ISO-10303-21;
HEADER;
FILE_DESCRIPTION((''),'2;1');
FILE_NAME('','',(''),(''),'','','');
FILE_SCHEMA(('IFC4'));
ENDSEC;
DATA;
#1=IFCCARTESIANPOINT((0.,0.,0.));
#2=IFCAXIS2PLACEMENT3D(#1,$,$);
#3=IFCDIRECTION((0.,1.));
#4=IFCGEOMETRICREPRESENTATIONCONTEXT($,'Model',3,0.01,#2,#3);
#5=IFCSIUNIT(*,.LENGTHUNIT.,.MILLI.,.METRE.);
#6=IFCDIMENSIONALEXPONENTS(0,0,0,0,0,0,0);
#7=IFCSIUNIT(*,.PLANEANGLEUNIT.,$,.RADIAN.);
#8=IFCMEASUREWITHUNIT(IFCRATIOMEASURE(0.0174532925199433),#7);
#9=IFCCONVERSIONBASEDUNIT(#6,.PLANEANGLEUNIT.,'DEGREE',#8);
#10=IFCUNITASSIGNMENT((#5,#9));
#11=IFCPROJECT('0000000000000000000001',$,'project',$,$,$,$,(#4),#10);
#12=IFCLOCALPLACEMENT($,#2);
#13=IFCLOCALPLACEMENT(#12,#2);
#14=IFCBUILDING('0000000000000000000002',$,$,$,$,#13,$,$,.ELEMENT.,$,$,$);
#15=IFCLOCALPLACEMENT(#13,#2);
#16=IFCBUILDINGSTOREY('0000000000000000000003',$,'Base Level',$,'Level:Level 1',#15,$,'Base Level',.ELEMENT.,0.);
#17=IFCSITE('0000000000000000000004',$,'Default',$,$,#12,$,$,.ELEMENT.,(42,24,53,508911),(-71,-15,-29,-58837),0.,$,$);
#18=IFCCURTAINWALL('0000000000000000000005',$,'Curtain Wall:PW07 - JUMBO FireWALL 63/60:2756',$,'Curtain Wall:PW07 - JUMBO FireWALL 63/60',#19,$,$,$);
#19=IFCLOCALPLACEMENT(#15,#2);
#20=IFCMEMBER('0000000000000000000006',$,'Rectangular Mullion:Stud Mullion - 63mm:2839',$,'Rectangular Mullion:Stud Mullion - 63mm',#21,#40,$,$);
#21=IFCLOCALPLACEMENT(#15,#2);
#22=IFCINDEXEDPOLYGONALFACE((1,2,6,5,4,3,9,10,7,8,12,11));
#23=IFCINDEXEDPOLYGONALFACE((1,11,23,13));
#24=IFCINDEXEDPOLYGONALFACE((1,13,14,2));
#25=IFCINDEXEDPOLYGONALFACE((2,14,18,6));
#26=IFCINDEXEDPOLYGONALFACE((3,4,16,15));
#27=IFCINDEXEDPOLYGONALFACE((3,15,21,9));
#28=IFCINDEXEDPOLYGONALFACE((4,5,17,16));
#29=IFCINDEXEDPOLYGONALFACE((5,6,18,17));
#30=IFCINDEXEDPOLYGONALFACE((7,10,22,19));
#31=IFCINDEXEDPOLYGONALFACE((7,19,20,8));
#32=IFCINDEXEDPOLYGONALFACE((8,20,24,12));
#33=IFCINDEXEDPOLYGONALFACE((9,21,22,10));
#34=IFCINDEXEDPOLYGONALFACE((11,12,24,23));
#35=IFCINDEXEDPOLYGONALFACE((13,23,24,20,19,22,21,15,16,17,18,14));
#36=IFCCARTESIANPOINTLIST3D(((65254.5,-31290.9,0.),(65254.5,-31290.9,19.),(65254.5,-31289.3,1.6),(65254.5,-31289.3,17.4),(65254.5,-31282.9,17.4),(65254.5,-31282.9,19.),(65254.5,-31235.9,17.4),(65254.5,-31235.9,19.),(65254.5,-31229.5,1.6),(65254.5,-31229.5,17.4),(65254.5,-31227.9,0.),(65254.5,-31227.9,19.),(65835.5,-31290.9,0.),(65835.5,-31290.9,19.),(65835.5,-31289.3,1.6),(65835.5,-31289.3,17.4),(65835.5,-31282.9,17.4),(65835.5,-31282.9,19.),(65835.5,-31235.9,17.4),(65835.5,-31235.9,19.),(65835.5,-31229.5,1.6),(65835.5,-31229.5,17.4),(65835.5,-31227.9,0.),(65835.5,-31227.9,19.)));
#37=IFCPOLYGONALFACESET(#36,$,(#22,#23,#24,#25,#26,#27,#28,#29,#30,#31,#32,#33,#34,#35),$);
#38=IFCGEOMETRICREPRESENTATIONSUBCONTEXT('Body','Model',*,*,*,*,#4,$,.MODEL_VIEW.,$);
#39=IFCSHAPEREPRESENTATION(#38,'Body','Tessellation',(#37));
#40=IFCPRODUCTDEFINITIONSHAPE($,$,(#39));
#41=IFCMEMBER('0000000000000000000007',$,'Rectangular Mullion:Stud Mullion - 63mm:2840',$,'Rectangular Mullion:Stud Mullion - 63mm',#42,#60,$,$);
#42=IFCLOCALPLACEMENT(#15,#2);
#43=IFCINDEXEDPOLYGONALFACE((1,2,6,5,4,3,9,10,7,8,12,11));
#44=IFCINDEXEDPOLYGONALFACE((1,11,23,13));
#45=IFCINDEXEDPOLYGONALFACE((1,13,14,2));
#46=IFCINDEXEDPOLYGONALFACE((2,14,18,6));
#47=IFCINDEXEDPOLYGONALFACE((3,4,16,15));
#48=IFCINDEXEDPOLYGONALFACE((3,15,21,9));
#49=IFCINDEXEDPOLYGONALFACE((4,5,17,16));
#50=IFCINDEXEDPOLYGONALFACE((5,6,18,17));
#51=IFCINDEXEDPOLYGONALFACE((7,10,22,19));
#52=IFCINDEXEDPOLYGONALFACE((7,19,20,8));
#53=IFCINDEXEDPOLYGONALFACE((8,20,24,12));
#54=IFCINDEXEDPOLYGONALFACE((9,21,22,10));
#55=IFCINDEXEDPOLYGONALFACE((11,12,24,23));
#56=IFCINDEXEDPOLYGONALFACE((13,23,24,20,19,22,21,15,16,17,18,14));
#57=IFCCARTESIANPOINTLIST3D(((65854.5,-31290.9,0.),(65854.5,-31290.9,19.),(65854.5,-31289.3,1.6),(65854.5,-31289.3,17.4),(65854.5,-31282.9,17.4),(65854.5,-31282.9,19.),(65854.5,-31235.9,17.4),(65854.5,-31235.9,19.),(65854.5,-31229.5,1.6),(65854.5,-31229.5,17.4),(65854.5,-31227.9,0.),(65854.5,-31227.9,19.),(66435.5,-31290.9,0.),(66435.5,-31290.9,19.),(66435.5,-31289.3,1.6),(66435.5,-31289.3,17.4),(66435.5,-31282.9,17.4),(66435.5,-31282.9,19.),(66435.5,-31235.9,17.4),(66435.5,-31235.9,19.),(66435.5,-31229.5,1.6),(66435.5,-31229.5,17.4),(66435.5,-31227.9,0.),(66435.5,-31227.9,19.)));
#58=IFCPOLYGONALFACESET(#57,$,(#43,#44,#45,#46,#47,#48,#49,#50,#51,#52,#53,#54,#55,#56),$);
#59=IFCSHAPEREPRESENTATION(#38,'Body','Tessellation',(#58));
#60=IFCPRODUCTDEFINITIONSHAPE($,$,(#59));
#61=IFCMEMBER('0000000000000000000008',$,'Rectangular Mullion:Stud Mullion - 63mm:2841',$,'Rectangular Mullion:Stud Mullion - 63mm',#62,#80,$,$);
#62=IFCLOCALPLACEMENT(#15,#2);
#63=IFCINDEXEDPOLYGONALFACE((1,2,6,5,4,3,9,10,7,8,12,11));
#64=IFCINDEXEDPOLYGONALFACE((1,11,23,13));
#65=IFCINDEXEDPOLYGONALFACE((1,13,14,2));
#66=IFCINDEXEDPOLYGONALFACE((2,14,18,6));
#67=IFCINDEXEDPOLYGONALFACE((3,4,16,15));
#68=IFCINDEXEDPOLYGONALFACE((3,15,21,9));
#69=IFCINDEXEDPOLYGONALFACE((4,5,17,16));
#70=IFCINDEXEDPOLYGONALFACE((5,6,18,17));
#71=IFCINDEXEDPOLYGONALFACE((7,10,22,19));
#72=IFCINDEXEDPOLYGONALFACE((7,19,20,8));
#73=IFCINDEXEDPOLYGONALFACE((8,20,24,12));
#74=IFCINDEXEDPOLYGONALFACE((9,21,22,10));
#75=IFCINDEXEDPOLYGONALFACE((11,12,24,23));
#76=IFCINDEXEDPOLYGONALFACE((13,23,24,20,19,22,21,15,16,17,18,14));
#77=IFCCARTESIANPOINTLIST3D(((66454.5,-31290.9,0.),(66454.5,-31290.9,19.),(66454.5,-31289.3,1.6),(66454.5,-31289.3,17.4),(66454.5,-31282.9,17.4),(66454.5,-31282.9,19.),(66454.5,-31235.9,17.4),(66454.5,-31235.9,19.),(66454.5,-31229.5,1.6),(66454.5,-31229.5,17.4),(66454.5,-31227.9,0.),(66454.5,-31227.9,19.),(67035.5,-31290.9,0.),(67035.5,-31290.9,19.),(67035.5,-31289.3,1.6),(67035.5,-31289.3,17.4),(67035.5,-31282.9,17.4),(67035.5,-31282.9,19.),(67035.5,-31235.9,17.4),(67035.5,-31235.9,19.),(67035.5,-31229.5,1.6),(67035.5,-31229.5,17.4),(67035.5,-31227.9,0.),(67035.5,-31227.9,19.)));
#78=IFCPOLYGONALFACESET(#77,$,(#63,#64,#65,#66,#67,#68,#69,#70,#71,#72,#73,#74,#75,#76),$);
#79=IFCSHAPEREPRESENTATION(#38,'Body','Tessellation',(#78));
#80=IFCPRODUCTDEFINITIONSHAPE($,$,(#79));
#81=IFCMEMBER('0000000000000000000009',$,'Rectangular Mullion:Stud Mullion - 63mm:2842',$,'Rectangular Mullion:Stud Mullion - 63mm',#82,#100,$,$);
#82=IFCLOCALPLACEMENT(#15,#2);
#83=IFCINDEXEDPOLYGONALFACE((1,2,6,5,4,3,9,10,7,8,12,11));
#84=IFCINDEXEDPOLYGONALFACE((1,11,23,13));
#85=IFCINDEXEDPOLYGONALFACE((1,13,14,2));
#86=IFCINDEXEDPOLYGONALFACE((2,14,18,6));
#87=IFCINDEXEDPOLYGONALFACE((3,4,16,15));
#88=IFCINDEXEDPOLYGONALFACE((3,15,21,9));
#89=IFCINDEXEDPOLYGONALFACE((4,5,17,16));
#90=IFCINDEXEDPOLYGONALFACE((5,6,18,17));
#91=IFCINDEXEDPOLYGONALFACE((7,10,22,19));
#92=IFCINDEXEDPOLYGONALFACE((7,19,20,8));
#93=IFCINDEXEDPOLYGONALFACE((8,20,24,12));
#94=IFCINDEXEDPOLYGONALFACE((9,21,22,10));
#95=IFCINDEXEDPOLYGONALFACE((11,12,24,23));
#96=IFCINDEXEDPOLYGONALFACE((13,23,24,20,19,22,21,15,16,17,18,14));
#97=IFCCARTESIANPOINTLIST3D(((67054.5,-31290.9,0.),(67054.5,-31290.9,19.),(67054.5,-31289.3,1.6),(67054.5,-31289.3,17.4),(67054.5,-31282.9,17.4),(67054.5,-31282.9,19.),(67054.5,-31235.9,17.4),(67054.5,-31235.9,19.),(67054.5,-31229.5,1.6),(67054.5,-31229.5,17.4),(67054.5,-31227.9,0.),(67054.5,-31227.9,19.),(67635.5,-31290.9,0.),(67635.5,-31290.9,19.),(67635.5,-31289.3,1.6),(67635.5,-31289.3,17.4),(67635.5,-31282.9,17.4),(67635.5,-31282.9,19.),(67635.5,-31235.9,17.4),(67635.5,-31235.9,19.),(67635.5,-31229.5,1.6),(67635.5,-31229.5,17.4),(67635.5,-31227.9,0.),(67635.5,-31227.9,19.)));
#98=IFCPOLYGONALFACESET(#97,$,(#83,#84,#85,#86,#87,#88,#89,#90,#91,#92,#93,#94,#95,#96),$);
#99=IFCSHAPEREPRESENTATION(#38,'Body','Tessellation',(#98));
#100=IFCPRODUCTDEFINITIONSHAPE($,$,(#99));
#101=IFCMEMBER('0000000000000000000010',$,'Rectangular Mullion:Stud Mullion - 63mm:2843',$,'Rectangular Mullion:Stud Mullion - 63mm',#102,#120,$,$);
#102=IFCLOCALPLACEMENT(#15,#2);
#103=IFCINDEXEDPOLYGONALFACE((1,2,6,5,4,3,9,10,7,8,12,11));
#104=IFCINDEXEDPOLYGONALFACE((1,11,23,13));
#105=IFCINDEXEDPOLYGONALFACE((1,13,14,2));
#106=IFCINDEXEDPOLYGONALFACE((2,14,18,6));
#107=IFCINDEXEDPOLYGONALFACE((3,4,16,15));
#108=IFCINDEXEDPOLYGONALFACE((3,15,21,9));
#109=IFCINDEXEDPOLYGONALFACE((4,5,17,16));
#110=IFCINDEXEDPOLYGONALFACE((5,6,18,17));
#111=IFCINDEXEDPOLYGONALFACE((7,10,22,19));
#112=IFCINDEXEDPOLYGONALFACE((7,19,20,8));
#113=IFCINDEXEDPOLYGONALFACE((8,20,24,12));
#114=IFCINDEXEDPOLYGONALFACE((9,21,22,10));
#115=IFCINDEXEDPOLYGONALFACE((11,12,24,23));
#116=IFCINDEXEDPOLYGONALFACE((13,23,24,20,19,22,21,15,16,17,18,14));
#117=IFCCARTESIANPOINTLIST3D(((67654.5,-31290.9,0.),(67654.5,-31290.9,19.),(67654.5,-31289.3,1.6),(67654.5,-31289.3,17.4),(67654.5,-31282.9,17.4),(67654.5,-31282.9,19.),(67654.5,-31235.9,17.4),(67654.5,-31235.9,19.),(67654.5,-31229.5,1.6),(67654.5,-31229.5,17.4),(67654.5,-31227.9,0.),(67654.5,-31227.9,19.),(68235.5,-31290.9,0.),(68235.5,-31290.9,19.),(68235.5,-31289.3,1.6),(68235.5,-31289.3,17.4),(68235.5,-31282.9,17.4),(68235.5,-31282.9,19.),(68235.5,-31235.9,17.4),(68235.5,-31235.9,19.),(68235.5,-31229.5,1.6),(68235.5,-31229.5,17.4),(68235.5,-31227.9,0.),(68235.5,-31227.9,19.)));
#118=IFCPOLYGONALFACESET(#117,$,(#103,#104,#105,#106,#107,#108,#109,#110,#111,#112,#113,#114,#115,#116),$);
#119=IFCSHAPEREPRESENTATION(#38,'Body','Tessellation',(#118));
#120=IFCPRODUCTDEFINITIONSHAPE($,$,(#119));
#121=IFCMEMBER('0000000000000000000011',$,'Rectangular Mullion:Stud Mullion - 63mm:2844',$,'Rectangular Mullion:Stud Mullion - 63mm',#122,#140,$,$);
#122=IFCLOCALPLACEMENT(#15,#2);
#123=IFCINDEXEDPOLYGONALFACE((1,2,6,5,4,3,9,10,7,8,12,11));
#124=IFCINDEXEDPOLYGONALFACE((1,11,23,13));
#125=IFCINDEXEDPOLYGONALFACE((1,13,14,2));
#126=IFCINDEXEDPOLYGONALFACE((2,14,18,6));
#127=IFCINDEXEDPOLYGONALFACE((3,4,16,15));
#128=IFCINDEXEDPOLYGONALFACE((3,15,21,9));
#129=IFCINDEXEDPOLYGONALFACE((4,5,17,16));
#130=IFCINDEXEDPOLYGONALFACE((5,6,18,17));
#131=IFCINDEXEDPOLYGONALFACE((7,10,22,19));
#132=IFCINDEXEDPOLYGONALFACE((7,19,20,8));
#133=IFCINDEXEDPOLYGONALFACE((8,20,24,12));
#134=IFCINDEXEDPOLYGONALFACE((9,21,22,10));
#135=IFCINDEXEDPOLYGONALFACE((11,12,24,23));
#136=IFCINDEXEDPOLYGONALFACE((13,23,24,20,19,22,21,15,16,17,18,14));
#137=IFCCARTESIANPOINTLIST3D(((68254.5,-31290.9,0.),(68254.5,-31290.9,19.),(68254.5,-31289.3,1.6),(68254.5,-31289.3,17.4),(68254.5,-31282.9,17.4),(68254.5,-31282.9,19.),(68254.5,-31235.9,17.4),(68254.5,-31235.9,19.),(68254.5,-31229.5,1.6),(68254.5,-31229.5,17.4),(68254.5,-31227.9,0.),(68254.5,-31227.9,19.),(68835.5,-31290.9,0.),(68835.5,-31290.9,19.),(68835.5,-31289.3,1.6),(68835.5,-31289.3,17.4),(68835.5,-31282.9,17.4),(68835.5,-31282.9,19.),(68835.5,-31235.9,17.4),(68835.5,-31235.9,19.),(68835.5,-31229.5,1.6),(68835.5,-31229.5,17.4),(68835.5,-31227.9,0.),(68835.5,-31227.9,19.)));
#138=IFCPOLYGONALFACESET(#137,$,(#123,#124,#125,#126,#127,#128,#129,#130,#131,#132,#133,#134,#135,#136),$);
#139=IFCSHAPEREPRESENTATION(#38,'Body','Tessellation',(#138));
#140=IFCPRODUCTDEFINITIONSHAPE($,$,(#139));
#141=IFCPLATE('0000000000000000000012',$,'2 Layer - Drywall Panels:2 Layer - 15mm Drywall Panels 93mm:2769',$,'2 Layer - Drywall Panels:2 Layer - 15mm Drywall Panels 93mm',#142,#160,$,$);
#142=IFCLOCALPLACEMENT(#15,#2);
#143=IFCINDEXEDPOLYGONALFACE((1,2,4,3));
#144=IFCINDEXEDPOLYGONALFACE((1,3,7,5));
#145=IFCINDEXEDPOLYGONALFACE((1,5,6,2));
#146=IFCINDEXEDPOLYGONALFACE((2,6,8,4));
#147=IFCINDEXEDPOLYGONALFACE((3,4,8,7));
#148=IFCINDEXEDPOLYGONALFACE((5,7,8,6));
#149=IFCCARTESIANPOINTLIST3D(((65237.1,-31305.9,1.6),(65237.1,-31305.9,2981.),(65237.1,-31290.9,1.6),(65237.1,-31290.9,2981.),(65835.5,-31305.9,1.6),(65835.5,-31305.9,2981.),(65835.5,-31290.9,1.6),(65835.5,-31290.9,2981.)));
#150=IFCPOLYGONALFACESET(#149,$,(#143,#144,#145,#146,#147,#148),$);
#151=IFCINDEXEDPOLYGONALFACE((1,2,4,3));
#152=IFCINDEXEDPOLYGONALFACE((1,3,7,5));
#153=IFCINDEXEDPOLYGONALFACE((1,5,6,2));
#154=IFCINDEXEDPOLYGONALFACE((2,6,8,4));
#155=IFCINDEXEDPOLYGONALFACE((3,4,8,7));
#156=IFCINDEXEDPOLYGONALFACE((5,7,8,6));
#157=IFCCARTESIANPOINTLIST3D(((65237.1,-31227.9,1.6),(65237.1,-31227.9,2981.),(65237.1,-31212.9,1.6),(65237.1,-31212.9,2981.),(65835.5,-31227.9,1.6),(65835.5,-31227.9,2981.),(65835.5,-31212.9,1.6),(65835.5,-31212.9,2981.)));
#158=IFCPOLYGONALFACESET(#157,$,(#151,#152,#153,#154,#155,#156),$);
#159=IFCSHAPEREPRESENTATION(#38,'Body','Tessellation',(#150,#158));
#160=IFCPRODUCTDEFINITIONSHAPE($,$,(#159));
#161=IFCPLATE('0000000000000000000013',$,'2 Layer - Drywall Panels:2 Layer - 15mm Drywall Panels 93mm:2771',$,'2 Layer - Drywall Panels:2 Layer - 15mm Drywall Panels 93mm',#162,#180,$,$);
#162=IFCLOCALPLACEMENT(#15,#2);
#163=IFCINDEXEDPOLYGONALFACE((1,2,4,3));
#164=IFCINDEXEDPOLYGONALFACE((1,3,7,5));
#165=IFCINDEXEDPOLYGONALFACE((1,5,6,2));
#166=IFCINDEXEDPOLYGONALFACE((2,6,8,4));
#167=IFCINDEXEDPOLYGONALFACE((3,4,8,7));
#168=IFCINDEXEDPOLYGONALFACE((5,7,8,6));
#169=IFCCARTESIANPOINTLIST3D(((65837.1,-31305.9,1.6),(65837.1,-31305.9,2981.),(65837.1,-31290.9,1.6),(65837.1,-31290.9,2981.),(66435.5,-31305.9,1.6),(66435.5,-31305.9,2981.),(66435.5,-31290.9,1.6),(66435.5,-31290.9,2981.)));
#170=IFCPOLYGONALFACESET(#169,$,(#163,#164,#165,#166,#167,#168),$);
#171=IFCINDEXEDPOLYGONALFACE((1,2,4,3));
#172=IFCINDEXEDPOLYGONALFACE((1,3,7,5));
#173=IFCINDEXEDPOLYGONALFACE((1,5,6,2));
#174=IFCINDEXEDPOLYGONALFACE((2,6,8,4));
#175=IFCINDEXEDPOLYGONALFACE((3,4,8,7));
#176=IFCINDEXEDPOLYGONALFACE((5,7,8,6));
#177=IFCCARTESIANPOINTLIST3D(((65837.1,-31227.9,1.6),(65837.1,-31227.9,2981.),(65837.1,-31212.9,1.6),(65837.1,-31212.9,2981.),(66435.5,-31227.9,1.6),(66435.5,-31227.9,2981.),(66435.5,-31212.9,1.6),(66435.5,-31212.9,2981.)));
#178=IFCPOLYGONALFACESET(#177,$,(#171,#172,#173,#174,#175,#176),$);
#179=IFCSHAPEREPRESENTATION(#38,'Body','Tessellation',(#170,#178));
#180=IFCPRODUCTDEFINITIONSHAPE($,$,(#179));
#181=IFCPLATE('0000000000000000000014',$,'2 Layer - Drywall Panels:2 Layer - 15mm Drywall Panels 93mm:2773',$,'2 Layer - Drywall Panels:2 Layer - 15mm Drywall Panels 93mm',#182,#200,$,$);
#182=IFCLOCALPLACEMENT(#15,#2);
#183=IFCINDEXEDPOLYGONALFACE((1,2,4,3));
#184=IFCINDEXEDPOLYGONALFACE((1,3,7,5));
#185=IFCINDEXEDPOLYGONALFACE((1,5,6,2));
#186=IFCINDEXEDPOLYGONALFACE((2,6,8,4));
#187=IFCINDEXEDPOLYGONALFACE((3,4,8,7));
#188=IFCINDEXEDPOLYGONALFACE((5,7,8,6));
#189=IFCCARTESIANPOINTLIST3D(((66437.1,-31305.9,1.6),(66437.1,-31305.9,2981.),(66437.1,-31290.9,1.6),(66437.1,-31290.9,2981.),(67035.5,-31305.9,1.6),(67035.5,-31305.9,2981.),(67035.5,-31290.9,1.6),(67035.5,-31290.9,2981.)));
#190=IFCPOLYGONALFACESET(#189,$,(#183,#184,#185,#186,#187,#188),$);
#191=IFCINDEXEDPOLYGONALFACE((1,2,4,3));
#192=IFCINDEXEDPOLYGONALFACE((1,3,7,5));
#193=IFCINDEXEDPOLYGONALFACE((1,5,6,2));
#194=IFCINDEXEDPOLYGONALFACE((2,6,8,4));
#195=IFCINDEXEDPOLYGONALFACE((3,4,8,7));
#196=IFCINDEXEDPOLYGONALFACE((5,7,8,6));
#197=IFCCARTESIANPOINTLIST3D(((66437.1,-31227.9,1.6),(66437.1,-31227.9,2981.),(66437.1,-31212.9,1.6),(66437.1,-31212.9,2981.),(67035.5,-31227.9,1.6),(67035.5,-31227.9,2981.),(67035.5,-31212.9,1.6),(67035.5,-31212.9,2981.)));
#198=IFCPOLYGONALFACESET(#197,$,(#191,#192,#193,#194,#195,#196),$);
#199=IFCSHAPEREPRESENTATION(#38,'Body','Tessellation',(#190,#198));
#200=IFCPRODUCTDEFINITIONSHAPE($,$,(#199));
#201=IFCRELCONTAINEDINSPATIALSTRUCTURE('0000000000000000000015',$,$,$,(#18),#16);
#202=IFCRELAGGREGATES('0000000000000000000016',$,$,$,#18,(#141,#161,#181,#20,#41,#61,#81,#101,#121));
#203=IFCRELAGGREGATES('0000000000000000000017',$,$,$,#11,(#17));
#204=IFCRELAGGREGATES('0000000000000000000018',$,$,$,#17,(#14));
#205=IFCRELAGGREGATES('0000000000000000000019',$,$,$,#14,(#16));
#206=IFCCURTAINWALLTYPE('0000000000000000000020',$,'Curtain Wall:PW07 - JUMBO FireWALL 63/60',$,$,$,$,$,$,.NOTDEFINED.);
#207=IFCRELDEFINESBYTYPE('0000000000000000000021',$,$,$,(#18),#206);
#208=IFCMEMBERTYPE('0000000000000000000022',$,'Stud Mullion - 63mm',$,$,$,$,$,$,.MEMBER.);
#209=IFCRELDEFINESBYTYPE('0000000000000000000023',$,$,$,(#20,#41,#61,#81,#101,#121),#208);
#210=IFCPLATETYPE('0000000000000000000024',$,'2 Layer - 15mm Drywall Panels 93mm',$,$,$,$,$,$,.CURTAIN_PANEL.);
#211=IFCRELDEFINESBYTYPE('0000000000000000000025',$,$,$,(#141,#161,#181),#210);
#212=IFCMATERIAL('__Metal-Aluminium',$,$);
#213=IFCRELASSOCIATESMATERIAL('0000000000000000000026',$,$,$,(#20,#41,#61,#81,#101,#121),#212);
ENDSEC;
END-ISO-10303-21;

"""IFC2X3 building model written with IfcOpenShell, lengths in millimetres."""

from ifc_helpers import new_model, entity, si_unit, converted_unit, direction, frame, frame_2d, origin, place, context, subcontext, project, spatial, polyline, rectangle, outline, extrude, source, transform, mapped, material, type_object, type_shapes, element, aggregate, save


model = new_model("IFC2X3")

# Units and contexts
model_context = context("Model", 3, precision=0.01, world=origin(), true_north=direction((0.0, 1.0)))
body_context = subcontext(model_context, "Body", "Model", "MODEL_VIEW")
ifc_project = project(units=[si_unit("LENGTHUNIT", "METRE", prefix="MILLI"), converted_unit("PLANEANGLEUNIT", "DEGREE", entity("IfcRatioMeasure", 0.0174532925199433), si_unit("PLANEANGLEUNIT", "RADIAN"), dimensions=[0, 0, 0, 0, 0, 0, 0])], contexts=[model_context])

# Site, building, storey
site_placement = place(None, origin())
site = spatial("IfcSite", under=ifc_project, at=site_placement, Name="Default", CompositionType="ELEMENT", RefLatitude=(42, 24, 53, 508911), RefLongitude=(-71, -15, -29, -58837), RefElevation=0.0)
building_placement = place(site_placement, origin())
building = spatial("IfcBuilding", under=site, at=building_placement, CompositionType="ELEMENT")
storey_placement = place(building_placement, origin())
storey = spatial("IfcBuildingStorey", under=building, at=storey_placement, Name="Base Level", ObjectType="Level:Level 1", LongName="Base Level", CompositionType="ELEMENT", Elevation=0.0)

# Curtain wall, members, plates
curtain_wall_type = type_object("IfcCurtainWallType", Name="Curtain Wall:PW07 - JUMBO FireWALL 63/60", PredefinedType="NOTDEFINED")
curtain_wall_placement = place(building_placement, origin())
curtain_wall = element("IfcCurtainWall", 1, at=curtain_wall_placement, inside=storey, type_object=curtain_wall_type, Name="Curtain Wall:PW07 - JUMBO FireWALL 63/60:2756", ObjectType="Curtain Wall:PW07 - JUMBO FireWALL 63/60")
ifc_material = material(Name="__Metal-Aluminium")
member_type_1 = type_object("IfcMemberType", Name="Stud Mullion - 63mm", PredefinedType="MEMBER")
shared_shape_1 = source(origin(), body_context, "Body", "SweptSolid", [
    extrude(outline(polyline([(23.5, -6.6), (31.5, -6.6), (31.5, 12.4), (-31.5, 12.4), (-31.5, -6.6), (-23.5, -6.6), (-23.5, -5.0), (-29.9, -5.0), (-29.9, 10.8), (29.9, 10.8), (29.9, -5.0), (23.5, -5.0), (23.5, -6.6)])), frame((-12.4, 0.0, -581.0), z_axis=(0.0, 0.0, 1.0), x_axis=(0.0, -1.0, 0.0)), (0.0, 0.0, 1.0), 581.0),
])
type_shapes(member_type_1, [shared_shape_1])
member_1_placement = place(building_placement, frame((65254.5, -31259.4, 0.0), z_axis=(-1.0, 0.0, 0.0), x_axis=(0.0, 0.0, -1.0)))
member_1 = element("IfcMember", 2, at=member_1_placement, type_object=member_type_1, material=ifc_material, Name="Rectangular Mullion:Stud Mullion - 63mm:2839", ObjectType="Rectangular Mullion:Stud Mullion - 63mm", context=body_context, shape_type="MappedRepresentation", body=[
    mapped(shared_shape_1, transform((0.0, 0.0, 0.0), scale=1.0)),
])
member_2_placement = place(building_placement, frame((65854.5, -31259.4, 0.0), z_axis=(-1.0, 0.0, 0.0), x_axis=(0.0, 0.0, -1.0)))
member_2 = element("IfcMember", 3, at=member_2_placement, type_object=member_type_1, material=ifc_material, Name="Rectangular Mullion:Stud Mullion - 63mm:2840", ObjectType="Rectangular Mullion:Stud Mullion - 63mm", context=body_context, shape_type="MappedRepresentation", body=[
    mapped(shared_shape_1, transform((0.0, 0.0, 0.0), scale=1.0)),
])
member_3_placement = place(building_placement, frame((66454.5, -31259.4, 0.0), z_axis=(-1.0, 0.0, 0.0), x_axis=(0.0, 0.0, -1.0)))
member_3 = element("IfcMember", 4, at=member_3_placement, type_object=member_type_1, material=ifc_material, Name="Rectangular Mullion:Stud Mullion - 63mm:2841", ObjectType="Rectangular Mullion:Stud Mullion - 63mm", context=body_context, shape_type="MappedRepresentation", body=[
    mapped(shared_shape_1, transform((0.0, 0.0, 0.0), scale=1.0)),
])
member_4_placement = place(building_placement, frame((67054.5, -31259.4, 0.0), z_axis=(-1.0, 0.0, 0.0), x_axis=(0.0, 0.0, -1.0)))
member_4 = element("IfcMember", 5, at=member_4_placement, type_object=member_type_1, material=ifc_material, Name="Rectangular Mullion:Stud Mullion - 63mm:2842", ObjectType="Rectangular Mullion:Stud Mullion - 63mm", context=body_context, shape_type="MappedRepresentation", body=[
    mapped(shared_shape_1, transform((0.0, 0.0, 0.0), scale=1.0)),
])
member_5_placement = place(building_placement, frame((67654.5, -31259.4, 0.0), z_axis=(-1.0, 0.0, 0.0), x_axis=(0.0, 0.0, -1.0)))
member_5 = element("IfcMember", 6, at=member_5_placement, type_object=member_type_1, material=ifc_material, Name="Rectangular Mullion:Stud Mullion - 63mm:2843", ObjectType="Rectangular Mullion:Stud Mullion - 63mm", context=body_context, shape_type="MappedRepresentation", body=[
    mapped(shared_shape_1, transform((0.0, 0.0, 0.0), scale=1.0)),
])
member_6_placement = place(building_placement, frame((68254.5, -31259.4, 0.0), z_axis=(-1.0, 0.0, 0.0), x_axis=(0.0, 0.0, -1.0)))
member_6 = element("IfcMember", 7, at=member_6_placement, type_object=member_type_1, material=ifc_material, Name="Rectangular Mullion:Stud Mullion - 63mm:2844", ObjectType="Rectangular Mullion:Stud Mullion - 63mm", context=body_context, shape_type="MappedRepresentation", body=[
    mapped(shared_shape_1, transform((0.0, 0.0, 0.0), scale=1.0)),
])
plate_type = type_object("IfcPlateType", Name="2 Layer - 15mm Drywall Panels 93mm", PredefinedType="CURTAIN_PANEL")
shared_shape_2 = source(origin(), body_context, "Body", "SweptSolid", [
    extrude(rectangle(XDim=598.4, YDim=15.0, at=frame_2d((0.0, 0.0), x_axis=(1.0, 0.0))), frame((0.0, -39.0, 0.0), z_axis=(0.0, 0.0, 1.0), x_axis=(-1.0, 0.0, 0.0)), (0.0, 0.0, 1.0), 2979.4),
    extrude(rectangle(XDim=15.0, YDim=598.4, at=frame_2d((0.0, 0.0), x_axis=(1.0, 0.0))), frame((0.0, 39.0, 0.0), z_axis=(0.0, 0.0, 1.0), x_axis=(0.0, 1.0, 0.0)), (0.0, 0.0, 1.0), 2979.4),
])
type_shapes(plate_type, [shared_shape_2])
plate_1_placement = place(curtain_wall_placement, frame((65536.3, -31259.4, 1.6)))
plate_1 = element("IfcPlate", 8, at=plate_1_placement, type_object=plate_type, Name="2 Layer - Drywall Panels:2 Layer - 15mm Drywall Panels 93mm:2769", ObjectType="2 Layer - Drywall Panels:2 Layer - 15mm Drywall Panels 93mm", context=body_context, shape_type="MappedRepresentation", body=[
    mapped(shared_shape_2, transform((0.0, 0.0, 0.0), scale=1.0)),
])
plate_2_placement = place(curtain_wall_placement, frame((66136.3, -31259.4, 1.6)))
plate_2 = element("IfcPlate", 9, at=plate_2_placement, type_object=plate_type, Name="2 Layer - Drywall Panels:2 Layer - 15mm Drywall Panels 93mm:2771", ObjectType="2 Layer - Drywall Panels:2 Layer - 15mm Drywall Panels 93mm", context=body_context, shape_type="MappedRepresentation", body=[
    mapped(shared_shape_2, transform((0.0, 0.0, 0.0), scale=1.0)),
])
plate_3_placement = place(curtain_wall_placement, frame((66736.3, -31259.4, 1.6)))
plate_3 = element("IfcPlate", 10, at=plate_3_placement, type_object=plate_type, Name="2 Layer - Drywall Panels:2 Layer - 15mm Drywall Panels 93mm:2773", ObjectType="2 Layer - Drywall Panels:2 Layer - 15mm Drywall Panels 93mm", context=body_context, shape_type="MappedRepresentation", body=[
    mapped(shared_shape_2, transform((0.0, 0.0, 0.0), scale=1.0)),
])
aggregate(curtain_wall, [plate_1, plate_2, plate_3, member_1, member_2, member_3, member_4, member_5, member_6])

save(model, "model.ifc")
